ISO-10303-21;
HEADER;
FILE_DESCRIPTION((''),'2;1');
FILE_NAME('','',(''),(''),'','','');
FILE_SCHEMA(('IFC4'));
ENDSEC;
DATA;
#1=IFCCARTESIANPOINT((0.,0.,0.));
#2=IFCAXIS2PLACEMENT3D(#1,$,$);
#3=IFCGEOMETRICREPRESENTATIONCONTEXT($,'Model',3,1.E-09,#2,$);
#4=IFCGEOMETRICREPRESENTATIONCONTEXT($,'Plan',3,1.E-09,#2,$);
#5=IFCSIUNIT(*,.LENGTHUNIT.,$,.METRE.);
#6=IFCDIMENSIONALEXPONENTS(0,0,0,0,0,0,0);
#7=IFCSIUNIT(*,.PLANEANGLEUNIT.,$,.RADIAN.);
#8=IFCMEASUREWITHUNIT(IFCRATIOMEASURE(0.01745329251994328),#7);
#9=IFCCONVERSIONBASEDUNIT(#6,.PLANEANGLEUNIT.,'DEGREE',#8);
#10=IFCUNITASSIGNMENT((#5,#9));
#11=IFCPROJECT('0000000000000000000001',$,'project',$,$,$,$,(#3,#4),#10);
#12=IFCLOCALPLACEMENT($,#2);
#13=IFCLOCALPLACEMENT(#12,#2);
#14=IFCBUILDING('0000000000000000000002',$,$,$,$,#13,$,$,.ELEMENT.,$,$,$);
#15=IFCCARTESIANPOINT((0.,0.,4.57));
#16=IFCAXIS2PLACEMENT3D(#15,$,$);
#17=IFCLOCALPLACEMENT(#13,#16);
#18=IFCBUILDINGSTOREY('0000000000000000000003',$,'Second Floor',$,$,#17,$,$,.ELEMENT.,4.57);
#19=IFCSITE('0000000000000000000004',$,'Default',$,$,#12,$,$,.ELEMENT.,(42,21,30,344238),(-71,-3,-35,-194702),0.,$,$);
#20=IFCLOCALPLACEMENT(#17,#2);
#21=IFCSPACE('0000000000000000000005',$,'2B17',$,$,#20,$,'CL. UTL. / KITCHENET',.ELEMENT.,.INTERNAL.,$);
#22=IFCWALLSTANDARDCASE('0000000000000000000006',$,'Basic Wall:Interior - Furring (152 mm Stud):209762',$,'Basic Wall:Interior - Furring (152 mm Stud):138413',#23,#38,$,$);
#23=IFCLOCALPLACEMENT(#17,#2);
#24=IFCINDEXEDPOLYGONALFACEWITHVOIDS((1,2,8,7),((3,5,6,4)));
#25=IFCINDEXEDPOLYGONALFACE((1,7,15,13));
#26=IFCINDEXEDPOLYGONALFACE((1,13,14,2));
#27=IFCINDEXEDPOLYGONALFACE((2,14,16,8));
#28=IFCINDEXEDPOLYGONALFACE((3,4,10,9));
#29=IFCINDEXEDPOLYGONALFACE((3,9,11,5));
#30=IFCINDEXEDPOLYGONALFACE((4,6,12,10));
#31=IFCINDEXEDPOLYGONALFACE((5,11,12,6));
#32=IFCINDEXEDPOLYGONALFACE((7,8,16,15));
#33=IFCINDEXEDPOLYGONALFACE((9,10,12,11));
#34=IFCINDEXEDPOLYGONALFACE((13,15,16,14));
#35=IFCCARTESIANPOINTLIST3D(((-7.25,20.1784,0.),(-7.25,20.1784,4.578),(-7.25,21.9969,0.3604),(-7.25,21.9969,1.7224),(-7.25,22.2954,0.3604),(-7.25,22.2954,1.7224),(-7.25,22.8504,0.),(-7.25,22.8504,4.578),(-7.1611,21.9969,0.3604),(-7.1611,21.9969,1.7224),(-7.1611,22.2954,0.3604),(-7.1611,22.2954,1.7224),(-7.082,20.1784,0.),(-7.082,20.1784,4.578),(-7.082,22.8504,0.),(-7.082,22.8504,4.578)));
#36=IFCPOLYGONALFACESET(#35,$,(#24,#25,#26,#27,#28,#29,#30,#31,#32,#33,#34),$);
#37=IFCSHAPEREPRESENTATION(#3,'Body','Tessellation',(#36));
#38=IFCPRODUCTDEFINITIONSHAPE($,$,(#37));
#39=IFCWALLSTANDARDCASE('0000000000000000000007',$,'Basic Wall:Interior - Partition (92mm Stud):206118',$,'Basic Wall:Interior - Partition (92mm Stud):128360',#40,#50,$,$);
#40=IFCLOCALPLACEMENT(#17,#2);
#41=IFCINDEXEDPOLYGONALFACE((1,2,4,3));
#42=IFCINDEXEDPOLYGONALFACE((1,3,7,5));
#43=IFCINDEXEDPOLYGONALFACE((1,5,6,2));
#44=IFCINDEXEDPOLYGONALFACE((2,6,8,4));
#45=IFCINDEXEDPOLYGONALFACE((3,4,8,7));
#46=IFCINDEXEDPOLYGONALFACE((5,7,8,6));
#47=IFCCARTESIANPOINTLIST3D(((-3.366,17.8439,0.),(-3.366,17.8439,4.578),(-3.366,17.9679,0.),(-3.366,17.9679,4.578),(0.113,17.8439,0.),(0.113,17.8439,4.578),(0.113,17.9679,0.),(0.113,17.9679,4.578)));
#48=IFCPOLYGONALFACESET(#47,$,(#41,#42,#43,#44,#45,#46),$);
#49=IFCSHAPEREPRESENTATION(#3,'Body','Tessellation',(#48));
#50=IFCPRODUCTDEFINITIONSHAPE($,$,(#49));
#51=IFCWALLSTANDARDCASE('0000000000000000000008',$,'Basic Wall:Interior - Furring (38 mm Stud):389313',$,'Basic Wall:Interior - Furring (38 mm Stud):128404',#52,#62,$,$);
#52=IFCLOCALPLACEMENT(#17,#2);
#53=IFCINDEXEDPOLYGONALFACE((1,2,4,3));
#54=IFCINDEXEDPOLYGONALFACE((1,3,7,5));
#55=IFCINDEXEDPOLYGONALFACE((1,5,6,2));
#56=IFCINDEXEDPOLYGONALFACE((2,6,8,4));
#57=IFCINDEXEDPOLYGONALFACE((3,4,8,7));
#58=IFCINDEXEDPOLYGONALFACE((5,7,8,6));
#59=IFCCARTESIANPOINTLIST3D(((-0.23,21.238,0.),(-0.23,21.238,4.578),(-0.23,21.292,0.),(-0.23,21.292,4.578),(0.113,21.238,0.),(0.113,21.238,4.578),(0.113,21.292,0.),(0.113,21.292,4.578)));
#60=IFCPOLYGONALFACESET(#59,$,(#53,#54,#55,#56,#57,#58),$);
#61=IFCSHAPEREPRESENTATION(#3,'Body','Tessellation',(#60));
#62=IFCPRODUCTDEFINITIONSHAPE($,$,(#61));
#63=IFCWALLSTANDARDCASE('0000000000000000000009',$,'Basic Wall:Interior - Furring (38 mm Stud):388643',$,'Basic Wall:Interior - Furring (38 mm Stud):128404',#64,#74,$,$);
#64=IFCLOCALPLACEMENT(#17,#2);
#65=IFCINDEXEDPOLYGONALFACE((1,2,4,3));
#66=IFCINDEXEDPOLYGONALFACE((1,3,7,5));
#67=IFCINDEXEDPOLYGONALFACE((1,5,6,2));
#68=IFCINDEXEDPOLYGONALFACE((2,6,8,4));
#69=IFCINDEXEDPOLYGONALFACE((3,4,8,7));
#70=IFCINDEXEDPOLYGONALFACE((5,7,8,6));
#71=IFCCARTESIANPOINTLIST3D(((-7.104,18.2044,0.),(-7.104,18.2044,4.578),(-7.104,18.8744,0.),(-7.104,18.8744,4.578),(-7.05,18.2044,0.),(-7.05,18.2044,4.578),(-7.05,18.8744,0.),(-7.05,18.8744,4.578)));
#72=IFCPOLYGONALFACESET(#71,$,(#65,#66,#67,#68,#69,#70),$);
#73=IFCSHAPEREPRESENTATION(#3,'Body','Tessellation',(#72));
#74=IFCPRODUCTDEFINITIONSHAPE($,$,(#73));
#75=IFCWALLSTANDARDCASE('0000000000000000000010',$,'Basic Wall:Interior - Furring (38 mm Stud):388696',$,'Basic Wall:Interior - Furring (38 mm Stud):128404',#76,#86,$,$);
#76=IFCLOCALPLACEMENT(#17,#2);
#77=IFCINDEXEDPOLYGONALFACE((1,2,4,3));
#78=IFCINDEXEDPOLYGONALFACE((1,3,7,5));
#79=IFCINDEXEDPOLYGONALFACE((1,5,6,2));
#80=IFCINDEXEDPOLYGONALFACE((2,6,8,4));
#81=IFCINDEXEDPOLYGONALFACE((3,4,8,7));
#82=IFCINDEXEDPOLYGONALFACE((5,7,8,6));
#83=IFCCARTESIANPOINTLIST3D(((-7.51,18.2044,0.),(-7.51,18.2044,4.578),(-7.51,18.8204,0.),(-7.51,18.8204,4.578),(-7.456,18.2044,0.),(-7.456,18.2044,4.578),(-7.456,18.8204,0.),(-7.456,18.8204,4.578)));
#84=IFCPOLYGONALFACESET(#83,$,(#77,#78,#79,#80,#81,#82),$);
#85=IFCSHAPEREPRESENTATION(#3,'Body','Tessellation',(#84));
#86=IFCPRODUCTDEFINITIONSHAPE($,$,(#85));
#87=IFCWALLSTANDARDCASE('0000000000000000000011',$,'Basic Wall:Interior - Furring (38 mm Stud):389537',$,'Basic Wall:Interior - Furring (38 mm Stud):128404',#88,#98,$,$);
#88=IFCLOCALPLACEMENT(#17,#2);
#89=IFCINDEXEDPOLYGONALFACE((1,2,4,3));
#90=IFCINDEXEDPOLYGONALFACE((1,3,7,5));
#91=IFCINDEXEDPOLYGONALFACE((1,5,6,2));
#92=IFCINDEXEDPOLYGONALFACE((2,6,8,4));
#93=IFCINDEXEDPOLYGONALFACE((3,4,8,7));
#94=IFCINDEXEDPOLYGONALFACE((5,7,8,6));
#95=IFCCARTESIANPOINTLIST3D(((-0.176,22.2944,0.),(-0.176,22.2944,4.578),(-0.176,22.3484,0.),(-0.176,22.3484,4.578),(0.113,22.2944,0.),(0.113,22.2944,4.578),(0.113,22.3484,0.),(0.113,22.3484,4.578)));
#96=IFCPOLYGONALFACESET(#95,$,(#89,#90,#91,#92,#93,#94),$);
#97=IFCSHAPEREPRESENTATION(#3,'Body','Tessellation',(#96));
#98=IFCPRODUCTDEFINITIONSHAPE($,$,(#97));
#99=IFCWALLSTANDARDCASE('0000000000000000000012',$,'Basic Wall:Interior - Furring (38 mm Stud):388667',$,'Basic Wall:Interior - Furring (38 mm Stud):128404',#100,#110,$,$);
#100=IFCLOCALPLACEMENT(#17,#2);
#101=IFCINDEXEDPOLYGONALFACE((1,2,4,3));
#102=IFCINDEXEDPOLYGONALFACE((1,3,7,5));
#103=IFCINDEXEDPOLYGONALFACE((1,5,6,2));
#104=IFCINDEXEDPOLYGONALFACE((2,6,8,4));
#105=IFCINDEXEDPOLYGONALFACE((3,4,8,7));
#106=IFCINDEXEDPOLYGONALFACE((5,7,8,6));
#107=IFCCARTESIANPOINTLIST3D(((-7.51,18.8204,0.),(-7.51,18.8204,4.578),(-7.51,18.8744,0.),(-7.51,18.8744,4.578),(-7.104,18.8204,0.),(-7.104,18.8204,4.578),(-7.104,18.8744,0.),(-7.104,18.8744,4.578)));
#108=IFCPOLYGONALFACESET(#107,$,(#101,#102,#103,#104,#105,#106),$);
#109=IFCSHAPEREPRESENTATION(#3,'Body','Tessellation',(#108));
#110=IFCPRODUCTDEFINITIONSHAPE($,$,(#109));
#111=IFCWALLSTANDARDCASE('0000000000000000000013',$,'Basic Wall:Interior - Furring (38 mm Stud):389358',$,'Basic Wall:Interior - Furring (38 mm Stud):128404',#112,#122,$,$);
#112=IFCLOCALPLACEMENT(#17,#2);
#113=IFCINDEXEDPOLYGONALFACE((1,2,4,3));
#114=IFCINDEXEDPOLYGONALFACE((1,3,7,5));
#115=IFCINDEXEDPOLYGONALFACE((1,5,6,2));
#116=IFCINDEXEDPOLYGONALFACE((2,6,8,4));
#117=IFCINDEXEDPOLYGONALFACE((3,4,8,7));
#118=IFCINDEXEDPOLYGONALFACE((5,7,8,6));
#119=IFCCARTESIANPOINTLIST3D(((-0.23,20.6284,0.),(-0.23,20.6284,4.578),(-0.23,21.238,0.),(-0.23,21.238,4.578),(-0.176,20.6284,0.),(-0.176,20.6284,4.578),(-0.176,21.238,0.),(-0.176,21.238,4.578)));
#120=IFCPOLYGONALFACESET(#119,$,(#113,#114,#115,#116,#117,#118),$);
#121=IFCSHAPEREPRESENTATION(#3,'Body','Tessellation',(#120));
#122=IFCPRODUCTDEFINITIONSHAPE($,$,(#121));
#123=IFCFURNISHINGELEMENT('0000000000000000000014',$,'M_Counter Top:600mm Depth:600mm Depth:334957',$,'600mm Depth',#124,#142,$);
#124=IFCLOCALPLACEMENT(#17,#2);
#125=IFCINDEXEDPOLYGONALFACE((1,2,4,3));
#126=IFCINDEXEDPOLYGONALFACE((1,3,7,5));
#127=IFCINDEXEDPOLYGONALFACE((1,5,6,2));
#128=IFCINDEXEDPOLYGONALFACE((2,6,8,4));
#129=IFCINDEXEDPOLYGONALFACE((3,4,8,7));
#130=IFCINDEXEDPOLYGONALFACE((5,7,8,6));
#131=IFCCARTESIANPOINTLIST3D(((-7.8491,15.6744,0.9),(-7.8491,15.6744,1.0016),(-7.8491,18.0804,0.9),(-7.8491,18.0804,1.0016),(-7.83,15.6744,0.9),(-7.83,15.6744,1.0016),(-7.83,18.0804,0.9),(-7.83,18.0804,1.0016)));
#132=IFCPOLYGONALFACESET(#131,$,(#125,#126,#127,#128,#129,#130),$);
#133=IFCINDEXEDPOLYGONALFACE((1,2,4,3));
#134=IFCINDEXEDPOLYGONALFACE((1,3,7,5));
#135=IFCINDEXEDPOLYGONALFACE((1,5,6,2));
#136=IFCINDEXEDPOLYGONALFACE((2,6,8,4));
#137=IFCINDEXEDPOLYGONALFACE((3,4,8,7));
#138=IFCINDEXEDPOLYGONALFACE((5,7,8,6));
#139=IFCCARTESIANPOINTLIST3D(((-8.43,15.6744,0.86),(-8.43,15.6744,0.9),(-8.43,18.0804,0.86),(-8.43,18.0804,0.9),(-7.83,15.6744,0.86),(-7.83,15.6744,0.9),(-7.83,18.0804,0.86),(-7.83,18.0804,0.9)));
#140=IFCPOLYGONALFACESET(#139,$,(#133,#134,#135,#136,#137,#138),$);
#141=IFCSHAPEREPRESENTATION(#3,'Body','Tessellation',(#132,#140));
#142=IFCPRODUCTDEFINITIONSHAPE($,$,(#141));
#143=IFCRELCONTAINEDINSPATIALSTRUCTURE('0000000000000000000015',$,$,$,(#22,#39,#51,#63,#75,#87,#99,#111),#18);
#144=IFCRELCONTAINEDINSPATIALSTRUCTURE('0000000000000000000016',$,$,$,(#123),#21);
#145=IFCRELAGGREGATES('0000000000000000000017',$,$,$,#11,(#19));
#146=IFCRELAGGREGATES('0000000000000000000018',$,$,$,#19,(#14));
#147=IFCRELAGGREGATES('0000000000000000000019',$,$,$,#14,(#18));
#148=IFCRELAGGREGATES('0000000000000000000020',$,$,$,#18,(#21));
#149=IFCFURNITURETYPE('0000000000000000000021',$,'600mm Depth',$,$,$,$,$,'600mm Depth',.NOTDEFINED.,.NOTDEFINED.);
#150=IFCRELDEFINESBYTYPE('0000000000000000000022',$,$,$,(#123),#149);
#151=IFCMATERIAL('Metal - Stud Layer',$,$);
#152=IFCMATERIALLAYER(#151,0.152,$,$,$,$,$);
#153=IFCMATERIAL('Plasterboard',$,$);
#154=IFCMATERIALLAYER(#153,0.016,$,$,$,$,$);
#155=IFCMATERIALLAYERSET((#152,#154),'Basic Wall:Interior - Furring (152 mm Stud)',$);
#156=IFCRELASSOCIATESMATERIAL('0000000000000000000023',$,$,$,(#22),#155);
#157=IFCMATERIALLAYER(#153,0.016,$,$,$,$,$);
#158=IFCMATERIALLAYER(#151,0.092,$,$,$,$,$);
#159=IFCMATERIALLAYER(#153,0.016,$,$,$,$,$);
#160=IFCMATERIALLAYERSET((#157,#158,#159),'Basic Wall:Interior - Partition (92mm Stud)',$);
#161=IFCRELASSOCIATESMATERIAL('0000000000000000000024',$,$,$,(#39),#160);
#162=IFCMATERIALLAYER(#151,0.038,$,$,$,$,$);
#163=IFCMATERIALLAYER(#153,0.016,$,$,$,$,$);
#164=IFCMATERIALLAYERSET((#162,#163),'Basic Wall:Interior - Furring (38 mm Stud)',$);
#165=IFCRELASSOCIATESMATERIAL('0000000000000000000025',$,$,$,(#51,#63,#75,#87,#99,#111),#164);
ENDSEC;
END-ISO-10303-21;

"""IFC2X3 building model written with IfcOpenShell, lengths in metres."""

from ifc_helpers import new_model, entity, si_unit, converted_unit, frame, frame_2d, origin, origin_2d_with_axis, place, context, project, spatial, rectangle, extrude, source, transform, mapped, material, layer, layer_set, layer_usage, type_object, type_shapes, element, save


model = new_model("IFC2X3")

# Units and contexts
model_context = context("Model", 3, precision=1e-09, world=origin())
plan_context = context("Plan", 3, precision=1e-09, world=origin())
ifc_project = project(units=[si_unit("LENGTHUNIT", "METRE"), converted_unit("PLANEANGLEUNIT", "DEGREE", entity("IfcRatioMeasure", 0.01745329251994328), si_unit("PLANEANGLEUNIT", "RADIAN"), dimensions=[0, 0, 0, 0, 0, 0, 0])], contexts=[model_context, plan_context])

# Site, building, storey
site_placement = place(None, origin())
site = spatial("IfcSite", under=ifc_project, at=site_placement, Name="Default", CompositionType="ELEMENT", RefLatitude=(42, 21, 30, 344238), RefLongitude=(-71, -3, -35, -194702), RefElevation=0.0)
building_placement = place(site_placement, origin())
building = spatial("IfcBuilding", under=site, at=building_placement, CompositionType="ELEMENT")
storey_placement = place(building_placement, frame((0.0, 0.0, 4.57)))
storey = spatial("IfcBuildingStorey", under=building, at=storey_placement, Name="Second Floor", CompositionType="ELEMENT", Elevation=4.57)

# Shared definitions
ifc_material_1 = material(Name="Plasterboard")
ifc_layer_1 = layer(ifc_material_1, 0.016)
ifc_material_2 = material(Name="Metal - Stud Layer")
ifc_layer_2 = layer(ifc_material_2, 0.092)
ifc_layer_3 = layer(ifc_material_1, 0.016)
ifc_layer_set_1 = layer_set([ifc_layer_1, ifc_layer_2, ifc_layer_3], Name="Basic Wall:Interior - Partition (92mm Stud)")
ifc_layer_usage_1 = layer_usage(ifc_layer_set_1, "AXIS2", "NEGATIVE", 0.062)

# Shared definitions
ifc_layer_4 = layer(ifc_material_2, 0.038)
ifc_layer_5 = layer(ifc_material_1, 0.016)
ifc_layer_set_2 = layer_set([ifc_layer_4, ifc_layer_5], Name="Basic Wall:Interior - Furring (38 mm Stud)")
ifc_layer_usage_2 = layer_usage(ifc_layer_set_2, "AXIS2", "NEGATIVE", 0.027)

# Wall, opening
ifc_layer_6 = layer(ifc_material_2, 0.152)
ifc_layer_7 = layer(ifc_material_1, 0.016)
ifc_layer_set_3 = layer_set([ifc_layer_6, ifc_layer_7], Name="Basic Wall:Interior - Furring (152 mm Stud)")
ifc_layer_usage_3 = layer_usage(ifc_layer_set_3, "AXIS2", "POSITIVE", -0.084)
wall_1_placement = place(storey_placement, frame((-7.166, 20.1784, 0.0), z_axis=(0.0, 0.0, 1.0), x_axis=(0.0, 1.0, 0.0)))
wall_1 = element("IfcWallStandardCase", 1, at=wall_1_placement, inside=storey, material=ifc_layer_usage_3, Name="Basic Wall:Interior - Furring (152 mm Stud):209762", ObjectType="Basic Wall:Interior - Furring (152 mm Stud):138413", context=model_context, shape_type="SweptSolid", body=[
    extrude(rectangle(XDim=2.672, YDim=0.168, at=frame_2d((1.336, 0.0), x_axis=(-1.0, 0.0))), origin(), (0.0, 0.0, 1.0), 4.578),
])
opening_1_placement = place(wall_1_placement, origin())
element("IfcOpeningElement", 2, at=opening_1_placement, cuts=wall_1, ObjectType="Opening", context=model_context, shape_type="SweptSolid", body=[
    extrude(rectangle(XDim=1.3621, YDim=0.2985, at=frame_2d((0.0, 0.0), x_axis=(0.0, 1.0))), frame((1.9677, -0.0049, 1.0414), z_axis=(0.0, 1.0, 0.0), x_axis=(1.0, 0.0, 0.0)), (0.0, 0.0, 1.0), 0.1524),
])

# Walls
wall_2_placement = place(storey_placement, frame((0.113, 17.9059, 0.0), z_axis=(0.0, 0.0, 1.0), x_axis=(-1.0, 0.0, 0.0)))
element("IfcWallStandardCase", 3, at=wall_2_placement, inside=storey, material=ifc_layer_usage_1, Name="Basic Wall:Interior - Partition (92mm Stud):206118", ObjectType="Basic Wall:Interior - Partition (92mm Stud):128360", context=model_context, shape_type="SweptSolid", body=[
    extrude(rectangle(XDim=3.479, YDim=0.124, at=frame_2d((1.7395, 0.0), x_axis=(-1.0, 0.0))), origin(), (0.0, 0.0, 1.0), 4.578),
])
wall_3_placement = place(storey_placement, frame((0.113, 21.265, 0.0), z_axis=(0.0, 0.0, 1.0), x_axis=(-1.0, 0.0, 0.0)))
element("IfcWallStandardCase", 4, at=wall_3_placement, inside=storey, material=ifc_layer_usage_2, Name="Basic Wall:Interior - Furring (38 mm Stud):389313", ObjectType="Basic Wall:Interior - Furring (38 mm Stud):128404", context=model_context, shape_type="SweptSolid", body=[
    extrude(rectangle(XDim=0.343, YDim=0.054, at=frame_2d((0.1715, 0.0), x_axis=(-1.0, 0.0))), origin(), (0.0, 0.0, 1.0), 4.578),
])
wall_4_placement = place(storey_placement, frame((-7.077, 18.2044, 0.0), z_axis=(0.0, 0.0, 1.0), x_axis=(0.0, 1.0, 0.0)))
element("IfcWallStandardCase", 5, at=wall_4_placement, inside=storey, material=ifc_layer_usage_2, Name="Basic Wall:Interior - Furring (38 mm Stud):388643", ObjectType="Basic Wall:Interior - Furring (38 mm Stud):128404", context=model_context, shape_type="SweptSolid", body=[
    extrude(rectangle(XDim=0.67, YDim=0.054, at=frame_2d((0.335, 0.0), x_axis=(-1.0, 0.0))), origin(), (0.0, 0.0, 1.0), 4.578),
])
wall_5_placement = place(storey_placement, frame((-7.483, 18.8204, 0.0), z_axis=(0.0, 0.0, 1.0), x_axis=(0.0, -1.0, 0.0)))
element("IfcWallStandardCase", 6, at=wall_5_placement, inside=storey, material=ifc_layer_usage_2, Name="Basic Wall:Interior - Furring (38 mm Stud):388696", ObjectType="Basic Wall:Interior - Furring (38 mm Stud):128404", context=model_context, shape_type="SweptSolid", body=[
    extrude(rectangle(XDim=0.616, YDim=0.054, at=frame_2d((0.308, 0.0), x_axis=(-1.0, 0.0))), origin(), (0.0, 0.0, 1.0), 4.578),
])
wall_6_placement = place(storey_placement, frame((-0.176, 22.3214, 0.0)))
element("IfcWallStandardCase", 7, at=wall_6_placement, inside=storey, material=ifc_layer_usage_2, Name="Basic Wall:Interior - Furring (38 mm Stud):389537", ObjectType="Basic Wall:Interior - Furring (38 mm Stud):128404", context=model_context, shape_type="SweptSolid", body=[
    extrude(rectangle(XDim=0.289, YDim=0.054, at=frame_2d((0.1445, 0.0), x_axis=(-1.0, 0.0))), origin(), (0.0, 0.0, 1.0), 4.578),
])
wall_7_placement = place(storey_placement, frame((-7.104, 18.8474, 0.0), z_axis=(0.0, 0.0, 1.0), x_axis=(-1.0, 0.0, 0.0)))
element("IfcWallStandardCase", 8, at=wall_7_placement, inside=storey, material=ifc_layer_usage_2, Name="Basic Wall:Interior - Furring (38 mm Stud):388667", ObjectType="Basic Wall:Interior - Furring (38 mm Stud):128404", context=model_context, shape_type="SweptSolid", body=[
    extrude(rectangle(XDim=0.406, YDim=0.054, at=frame_2d((0.203, 0.0), x_axis=(-1.0, 0.0))), origin(), (0.0, 0.0, 1.0), 4.578),
])
wall_8_placement = place(storey_placement, frame((-0.203, 21.238, 0.0), z_axis=(0.0, 0.0, 1.0), x_axis=(0.0, -1.0, 0.0)))
element("IfcWallStandardCase", 9, at=wall_8_placement, inside=storey, material=ifc_layer_usage_2, Name="Basic Wall:Interior - Furring (38 mm Stud):389358", ObjectType="Basic Wall:Interior - Furring (38 mm Stud):128404", context=model_context, shape_type="SweptSolid", body=[
    extrude(rectangle(XDim=0.6096, YDim=0.054, at=frame_2d((0.3048, 0.0), x_axis=(-1.0, 0.0))), origin(), (0.0, 0.0, 1.0), 4.578),
])

# Shared definitions
space_1_placement = place(storey_placement, origin())
space_1 = spatial("IfcSpace", under=storey, at=space_1_placement, Name="2B17", LongName="CL. UTL. / KITCHENET", CompositionType="ELEMENT", InteriorOrExteriorSpace="INTERNAL")

# Furnishing element
furniture_type = type_object("IfcFurnitureType", Name="600mm Depth", ElementType="600mm Depth", AssemblyPlace="NOTDEFINED")
shared_shape_1 = source(origin(), model_context, "Body", "SweptSolid", [
    extrude(rectangle(XDim=0.0191, YDim=2.406, at=origin_2d_with_axis()), frame((0.0025, -0.0095, 0.9), z_axis=(0.0, 0.0, 1.0), x_axis=(0.0, -1.0, 0.0)), (0.0, 0.0, 1.0), 0.1016),
    extrude(rectangle(XDim=2.406, YDim=0.6, at=origin_2d_with_axis()), frame((0.0025, -0.3, 0.86), z_axis=(0.0, 0.0, 1.0), x_axis=(-1.0, 0.0, 0.0)), (0.0, 0.0, 1.0), 0.04),
])
type_shapes(furniture_type, [shared_shape_1])
furnishing_placement = place(space_1_placement, frame((-7.83, 16.88, 0.0), z_axis=(0.0, 0.0, 1.0), x_axis=(0.0, -1.0, 0.0)))
element("IfcFurnishingElement", 10, at=furnishing_placement, inside=space_1, type_object=furniture_type, Name="M_Counter Top:600mm Depth:600mm Depth:334957", ObjectType="600mm Depth", context=model_context, shape_type="MappedRepresentation", body=[
    mapped(shared_shape_1, transform((0.0, 0.0, 0.0), scale=1.0)),
])

save(model, "model.ifc")
